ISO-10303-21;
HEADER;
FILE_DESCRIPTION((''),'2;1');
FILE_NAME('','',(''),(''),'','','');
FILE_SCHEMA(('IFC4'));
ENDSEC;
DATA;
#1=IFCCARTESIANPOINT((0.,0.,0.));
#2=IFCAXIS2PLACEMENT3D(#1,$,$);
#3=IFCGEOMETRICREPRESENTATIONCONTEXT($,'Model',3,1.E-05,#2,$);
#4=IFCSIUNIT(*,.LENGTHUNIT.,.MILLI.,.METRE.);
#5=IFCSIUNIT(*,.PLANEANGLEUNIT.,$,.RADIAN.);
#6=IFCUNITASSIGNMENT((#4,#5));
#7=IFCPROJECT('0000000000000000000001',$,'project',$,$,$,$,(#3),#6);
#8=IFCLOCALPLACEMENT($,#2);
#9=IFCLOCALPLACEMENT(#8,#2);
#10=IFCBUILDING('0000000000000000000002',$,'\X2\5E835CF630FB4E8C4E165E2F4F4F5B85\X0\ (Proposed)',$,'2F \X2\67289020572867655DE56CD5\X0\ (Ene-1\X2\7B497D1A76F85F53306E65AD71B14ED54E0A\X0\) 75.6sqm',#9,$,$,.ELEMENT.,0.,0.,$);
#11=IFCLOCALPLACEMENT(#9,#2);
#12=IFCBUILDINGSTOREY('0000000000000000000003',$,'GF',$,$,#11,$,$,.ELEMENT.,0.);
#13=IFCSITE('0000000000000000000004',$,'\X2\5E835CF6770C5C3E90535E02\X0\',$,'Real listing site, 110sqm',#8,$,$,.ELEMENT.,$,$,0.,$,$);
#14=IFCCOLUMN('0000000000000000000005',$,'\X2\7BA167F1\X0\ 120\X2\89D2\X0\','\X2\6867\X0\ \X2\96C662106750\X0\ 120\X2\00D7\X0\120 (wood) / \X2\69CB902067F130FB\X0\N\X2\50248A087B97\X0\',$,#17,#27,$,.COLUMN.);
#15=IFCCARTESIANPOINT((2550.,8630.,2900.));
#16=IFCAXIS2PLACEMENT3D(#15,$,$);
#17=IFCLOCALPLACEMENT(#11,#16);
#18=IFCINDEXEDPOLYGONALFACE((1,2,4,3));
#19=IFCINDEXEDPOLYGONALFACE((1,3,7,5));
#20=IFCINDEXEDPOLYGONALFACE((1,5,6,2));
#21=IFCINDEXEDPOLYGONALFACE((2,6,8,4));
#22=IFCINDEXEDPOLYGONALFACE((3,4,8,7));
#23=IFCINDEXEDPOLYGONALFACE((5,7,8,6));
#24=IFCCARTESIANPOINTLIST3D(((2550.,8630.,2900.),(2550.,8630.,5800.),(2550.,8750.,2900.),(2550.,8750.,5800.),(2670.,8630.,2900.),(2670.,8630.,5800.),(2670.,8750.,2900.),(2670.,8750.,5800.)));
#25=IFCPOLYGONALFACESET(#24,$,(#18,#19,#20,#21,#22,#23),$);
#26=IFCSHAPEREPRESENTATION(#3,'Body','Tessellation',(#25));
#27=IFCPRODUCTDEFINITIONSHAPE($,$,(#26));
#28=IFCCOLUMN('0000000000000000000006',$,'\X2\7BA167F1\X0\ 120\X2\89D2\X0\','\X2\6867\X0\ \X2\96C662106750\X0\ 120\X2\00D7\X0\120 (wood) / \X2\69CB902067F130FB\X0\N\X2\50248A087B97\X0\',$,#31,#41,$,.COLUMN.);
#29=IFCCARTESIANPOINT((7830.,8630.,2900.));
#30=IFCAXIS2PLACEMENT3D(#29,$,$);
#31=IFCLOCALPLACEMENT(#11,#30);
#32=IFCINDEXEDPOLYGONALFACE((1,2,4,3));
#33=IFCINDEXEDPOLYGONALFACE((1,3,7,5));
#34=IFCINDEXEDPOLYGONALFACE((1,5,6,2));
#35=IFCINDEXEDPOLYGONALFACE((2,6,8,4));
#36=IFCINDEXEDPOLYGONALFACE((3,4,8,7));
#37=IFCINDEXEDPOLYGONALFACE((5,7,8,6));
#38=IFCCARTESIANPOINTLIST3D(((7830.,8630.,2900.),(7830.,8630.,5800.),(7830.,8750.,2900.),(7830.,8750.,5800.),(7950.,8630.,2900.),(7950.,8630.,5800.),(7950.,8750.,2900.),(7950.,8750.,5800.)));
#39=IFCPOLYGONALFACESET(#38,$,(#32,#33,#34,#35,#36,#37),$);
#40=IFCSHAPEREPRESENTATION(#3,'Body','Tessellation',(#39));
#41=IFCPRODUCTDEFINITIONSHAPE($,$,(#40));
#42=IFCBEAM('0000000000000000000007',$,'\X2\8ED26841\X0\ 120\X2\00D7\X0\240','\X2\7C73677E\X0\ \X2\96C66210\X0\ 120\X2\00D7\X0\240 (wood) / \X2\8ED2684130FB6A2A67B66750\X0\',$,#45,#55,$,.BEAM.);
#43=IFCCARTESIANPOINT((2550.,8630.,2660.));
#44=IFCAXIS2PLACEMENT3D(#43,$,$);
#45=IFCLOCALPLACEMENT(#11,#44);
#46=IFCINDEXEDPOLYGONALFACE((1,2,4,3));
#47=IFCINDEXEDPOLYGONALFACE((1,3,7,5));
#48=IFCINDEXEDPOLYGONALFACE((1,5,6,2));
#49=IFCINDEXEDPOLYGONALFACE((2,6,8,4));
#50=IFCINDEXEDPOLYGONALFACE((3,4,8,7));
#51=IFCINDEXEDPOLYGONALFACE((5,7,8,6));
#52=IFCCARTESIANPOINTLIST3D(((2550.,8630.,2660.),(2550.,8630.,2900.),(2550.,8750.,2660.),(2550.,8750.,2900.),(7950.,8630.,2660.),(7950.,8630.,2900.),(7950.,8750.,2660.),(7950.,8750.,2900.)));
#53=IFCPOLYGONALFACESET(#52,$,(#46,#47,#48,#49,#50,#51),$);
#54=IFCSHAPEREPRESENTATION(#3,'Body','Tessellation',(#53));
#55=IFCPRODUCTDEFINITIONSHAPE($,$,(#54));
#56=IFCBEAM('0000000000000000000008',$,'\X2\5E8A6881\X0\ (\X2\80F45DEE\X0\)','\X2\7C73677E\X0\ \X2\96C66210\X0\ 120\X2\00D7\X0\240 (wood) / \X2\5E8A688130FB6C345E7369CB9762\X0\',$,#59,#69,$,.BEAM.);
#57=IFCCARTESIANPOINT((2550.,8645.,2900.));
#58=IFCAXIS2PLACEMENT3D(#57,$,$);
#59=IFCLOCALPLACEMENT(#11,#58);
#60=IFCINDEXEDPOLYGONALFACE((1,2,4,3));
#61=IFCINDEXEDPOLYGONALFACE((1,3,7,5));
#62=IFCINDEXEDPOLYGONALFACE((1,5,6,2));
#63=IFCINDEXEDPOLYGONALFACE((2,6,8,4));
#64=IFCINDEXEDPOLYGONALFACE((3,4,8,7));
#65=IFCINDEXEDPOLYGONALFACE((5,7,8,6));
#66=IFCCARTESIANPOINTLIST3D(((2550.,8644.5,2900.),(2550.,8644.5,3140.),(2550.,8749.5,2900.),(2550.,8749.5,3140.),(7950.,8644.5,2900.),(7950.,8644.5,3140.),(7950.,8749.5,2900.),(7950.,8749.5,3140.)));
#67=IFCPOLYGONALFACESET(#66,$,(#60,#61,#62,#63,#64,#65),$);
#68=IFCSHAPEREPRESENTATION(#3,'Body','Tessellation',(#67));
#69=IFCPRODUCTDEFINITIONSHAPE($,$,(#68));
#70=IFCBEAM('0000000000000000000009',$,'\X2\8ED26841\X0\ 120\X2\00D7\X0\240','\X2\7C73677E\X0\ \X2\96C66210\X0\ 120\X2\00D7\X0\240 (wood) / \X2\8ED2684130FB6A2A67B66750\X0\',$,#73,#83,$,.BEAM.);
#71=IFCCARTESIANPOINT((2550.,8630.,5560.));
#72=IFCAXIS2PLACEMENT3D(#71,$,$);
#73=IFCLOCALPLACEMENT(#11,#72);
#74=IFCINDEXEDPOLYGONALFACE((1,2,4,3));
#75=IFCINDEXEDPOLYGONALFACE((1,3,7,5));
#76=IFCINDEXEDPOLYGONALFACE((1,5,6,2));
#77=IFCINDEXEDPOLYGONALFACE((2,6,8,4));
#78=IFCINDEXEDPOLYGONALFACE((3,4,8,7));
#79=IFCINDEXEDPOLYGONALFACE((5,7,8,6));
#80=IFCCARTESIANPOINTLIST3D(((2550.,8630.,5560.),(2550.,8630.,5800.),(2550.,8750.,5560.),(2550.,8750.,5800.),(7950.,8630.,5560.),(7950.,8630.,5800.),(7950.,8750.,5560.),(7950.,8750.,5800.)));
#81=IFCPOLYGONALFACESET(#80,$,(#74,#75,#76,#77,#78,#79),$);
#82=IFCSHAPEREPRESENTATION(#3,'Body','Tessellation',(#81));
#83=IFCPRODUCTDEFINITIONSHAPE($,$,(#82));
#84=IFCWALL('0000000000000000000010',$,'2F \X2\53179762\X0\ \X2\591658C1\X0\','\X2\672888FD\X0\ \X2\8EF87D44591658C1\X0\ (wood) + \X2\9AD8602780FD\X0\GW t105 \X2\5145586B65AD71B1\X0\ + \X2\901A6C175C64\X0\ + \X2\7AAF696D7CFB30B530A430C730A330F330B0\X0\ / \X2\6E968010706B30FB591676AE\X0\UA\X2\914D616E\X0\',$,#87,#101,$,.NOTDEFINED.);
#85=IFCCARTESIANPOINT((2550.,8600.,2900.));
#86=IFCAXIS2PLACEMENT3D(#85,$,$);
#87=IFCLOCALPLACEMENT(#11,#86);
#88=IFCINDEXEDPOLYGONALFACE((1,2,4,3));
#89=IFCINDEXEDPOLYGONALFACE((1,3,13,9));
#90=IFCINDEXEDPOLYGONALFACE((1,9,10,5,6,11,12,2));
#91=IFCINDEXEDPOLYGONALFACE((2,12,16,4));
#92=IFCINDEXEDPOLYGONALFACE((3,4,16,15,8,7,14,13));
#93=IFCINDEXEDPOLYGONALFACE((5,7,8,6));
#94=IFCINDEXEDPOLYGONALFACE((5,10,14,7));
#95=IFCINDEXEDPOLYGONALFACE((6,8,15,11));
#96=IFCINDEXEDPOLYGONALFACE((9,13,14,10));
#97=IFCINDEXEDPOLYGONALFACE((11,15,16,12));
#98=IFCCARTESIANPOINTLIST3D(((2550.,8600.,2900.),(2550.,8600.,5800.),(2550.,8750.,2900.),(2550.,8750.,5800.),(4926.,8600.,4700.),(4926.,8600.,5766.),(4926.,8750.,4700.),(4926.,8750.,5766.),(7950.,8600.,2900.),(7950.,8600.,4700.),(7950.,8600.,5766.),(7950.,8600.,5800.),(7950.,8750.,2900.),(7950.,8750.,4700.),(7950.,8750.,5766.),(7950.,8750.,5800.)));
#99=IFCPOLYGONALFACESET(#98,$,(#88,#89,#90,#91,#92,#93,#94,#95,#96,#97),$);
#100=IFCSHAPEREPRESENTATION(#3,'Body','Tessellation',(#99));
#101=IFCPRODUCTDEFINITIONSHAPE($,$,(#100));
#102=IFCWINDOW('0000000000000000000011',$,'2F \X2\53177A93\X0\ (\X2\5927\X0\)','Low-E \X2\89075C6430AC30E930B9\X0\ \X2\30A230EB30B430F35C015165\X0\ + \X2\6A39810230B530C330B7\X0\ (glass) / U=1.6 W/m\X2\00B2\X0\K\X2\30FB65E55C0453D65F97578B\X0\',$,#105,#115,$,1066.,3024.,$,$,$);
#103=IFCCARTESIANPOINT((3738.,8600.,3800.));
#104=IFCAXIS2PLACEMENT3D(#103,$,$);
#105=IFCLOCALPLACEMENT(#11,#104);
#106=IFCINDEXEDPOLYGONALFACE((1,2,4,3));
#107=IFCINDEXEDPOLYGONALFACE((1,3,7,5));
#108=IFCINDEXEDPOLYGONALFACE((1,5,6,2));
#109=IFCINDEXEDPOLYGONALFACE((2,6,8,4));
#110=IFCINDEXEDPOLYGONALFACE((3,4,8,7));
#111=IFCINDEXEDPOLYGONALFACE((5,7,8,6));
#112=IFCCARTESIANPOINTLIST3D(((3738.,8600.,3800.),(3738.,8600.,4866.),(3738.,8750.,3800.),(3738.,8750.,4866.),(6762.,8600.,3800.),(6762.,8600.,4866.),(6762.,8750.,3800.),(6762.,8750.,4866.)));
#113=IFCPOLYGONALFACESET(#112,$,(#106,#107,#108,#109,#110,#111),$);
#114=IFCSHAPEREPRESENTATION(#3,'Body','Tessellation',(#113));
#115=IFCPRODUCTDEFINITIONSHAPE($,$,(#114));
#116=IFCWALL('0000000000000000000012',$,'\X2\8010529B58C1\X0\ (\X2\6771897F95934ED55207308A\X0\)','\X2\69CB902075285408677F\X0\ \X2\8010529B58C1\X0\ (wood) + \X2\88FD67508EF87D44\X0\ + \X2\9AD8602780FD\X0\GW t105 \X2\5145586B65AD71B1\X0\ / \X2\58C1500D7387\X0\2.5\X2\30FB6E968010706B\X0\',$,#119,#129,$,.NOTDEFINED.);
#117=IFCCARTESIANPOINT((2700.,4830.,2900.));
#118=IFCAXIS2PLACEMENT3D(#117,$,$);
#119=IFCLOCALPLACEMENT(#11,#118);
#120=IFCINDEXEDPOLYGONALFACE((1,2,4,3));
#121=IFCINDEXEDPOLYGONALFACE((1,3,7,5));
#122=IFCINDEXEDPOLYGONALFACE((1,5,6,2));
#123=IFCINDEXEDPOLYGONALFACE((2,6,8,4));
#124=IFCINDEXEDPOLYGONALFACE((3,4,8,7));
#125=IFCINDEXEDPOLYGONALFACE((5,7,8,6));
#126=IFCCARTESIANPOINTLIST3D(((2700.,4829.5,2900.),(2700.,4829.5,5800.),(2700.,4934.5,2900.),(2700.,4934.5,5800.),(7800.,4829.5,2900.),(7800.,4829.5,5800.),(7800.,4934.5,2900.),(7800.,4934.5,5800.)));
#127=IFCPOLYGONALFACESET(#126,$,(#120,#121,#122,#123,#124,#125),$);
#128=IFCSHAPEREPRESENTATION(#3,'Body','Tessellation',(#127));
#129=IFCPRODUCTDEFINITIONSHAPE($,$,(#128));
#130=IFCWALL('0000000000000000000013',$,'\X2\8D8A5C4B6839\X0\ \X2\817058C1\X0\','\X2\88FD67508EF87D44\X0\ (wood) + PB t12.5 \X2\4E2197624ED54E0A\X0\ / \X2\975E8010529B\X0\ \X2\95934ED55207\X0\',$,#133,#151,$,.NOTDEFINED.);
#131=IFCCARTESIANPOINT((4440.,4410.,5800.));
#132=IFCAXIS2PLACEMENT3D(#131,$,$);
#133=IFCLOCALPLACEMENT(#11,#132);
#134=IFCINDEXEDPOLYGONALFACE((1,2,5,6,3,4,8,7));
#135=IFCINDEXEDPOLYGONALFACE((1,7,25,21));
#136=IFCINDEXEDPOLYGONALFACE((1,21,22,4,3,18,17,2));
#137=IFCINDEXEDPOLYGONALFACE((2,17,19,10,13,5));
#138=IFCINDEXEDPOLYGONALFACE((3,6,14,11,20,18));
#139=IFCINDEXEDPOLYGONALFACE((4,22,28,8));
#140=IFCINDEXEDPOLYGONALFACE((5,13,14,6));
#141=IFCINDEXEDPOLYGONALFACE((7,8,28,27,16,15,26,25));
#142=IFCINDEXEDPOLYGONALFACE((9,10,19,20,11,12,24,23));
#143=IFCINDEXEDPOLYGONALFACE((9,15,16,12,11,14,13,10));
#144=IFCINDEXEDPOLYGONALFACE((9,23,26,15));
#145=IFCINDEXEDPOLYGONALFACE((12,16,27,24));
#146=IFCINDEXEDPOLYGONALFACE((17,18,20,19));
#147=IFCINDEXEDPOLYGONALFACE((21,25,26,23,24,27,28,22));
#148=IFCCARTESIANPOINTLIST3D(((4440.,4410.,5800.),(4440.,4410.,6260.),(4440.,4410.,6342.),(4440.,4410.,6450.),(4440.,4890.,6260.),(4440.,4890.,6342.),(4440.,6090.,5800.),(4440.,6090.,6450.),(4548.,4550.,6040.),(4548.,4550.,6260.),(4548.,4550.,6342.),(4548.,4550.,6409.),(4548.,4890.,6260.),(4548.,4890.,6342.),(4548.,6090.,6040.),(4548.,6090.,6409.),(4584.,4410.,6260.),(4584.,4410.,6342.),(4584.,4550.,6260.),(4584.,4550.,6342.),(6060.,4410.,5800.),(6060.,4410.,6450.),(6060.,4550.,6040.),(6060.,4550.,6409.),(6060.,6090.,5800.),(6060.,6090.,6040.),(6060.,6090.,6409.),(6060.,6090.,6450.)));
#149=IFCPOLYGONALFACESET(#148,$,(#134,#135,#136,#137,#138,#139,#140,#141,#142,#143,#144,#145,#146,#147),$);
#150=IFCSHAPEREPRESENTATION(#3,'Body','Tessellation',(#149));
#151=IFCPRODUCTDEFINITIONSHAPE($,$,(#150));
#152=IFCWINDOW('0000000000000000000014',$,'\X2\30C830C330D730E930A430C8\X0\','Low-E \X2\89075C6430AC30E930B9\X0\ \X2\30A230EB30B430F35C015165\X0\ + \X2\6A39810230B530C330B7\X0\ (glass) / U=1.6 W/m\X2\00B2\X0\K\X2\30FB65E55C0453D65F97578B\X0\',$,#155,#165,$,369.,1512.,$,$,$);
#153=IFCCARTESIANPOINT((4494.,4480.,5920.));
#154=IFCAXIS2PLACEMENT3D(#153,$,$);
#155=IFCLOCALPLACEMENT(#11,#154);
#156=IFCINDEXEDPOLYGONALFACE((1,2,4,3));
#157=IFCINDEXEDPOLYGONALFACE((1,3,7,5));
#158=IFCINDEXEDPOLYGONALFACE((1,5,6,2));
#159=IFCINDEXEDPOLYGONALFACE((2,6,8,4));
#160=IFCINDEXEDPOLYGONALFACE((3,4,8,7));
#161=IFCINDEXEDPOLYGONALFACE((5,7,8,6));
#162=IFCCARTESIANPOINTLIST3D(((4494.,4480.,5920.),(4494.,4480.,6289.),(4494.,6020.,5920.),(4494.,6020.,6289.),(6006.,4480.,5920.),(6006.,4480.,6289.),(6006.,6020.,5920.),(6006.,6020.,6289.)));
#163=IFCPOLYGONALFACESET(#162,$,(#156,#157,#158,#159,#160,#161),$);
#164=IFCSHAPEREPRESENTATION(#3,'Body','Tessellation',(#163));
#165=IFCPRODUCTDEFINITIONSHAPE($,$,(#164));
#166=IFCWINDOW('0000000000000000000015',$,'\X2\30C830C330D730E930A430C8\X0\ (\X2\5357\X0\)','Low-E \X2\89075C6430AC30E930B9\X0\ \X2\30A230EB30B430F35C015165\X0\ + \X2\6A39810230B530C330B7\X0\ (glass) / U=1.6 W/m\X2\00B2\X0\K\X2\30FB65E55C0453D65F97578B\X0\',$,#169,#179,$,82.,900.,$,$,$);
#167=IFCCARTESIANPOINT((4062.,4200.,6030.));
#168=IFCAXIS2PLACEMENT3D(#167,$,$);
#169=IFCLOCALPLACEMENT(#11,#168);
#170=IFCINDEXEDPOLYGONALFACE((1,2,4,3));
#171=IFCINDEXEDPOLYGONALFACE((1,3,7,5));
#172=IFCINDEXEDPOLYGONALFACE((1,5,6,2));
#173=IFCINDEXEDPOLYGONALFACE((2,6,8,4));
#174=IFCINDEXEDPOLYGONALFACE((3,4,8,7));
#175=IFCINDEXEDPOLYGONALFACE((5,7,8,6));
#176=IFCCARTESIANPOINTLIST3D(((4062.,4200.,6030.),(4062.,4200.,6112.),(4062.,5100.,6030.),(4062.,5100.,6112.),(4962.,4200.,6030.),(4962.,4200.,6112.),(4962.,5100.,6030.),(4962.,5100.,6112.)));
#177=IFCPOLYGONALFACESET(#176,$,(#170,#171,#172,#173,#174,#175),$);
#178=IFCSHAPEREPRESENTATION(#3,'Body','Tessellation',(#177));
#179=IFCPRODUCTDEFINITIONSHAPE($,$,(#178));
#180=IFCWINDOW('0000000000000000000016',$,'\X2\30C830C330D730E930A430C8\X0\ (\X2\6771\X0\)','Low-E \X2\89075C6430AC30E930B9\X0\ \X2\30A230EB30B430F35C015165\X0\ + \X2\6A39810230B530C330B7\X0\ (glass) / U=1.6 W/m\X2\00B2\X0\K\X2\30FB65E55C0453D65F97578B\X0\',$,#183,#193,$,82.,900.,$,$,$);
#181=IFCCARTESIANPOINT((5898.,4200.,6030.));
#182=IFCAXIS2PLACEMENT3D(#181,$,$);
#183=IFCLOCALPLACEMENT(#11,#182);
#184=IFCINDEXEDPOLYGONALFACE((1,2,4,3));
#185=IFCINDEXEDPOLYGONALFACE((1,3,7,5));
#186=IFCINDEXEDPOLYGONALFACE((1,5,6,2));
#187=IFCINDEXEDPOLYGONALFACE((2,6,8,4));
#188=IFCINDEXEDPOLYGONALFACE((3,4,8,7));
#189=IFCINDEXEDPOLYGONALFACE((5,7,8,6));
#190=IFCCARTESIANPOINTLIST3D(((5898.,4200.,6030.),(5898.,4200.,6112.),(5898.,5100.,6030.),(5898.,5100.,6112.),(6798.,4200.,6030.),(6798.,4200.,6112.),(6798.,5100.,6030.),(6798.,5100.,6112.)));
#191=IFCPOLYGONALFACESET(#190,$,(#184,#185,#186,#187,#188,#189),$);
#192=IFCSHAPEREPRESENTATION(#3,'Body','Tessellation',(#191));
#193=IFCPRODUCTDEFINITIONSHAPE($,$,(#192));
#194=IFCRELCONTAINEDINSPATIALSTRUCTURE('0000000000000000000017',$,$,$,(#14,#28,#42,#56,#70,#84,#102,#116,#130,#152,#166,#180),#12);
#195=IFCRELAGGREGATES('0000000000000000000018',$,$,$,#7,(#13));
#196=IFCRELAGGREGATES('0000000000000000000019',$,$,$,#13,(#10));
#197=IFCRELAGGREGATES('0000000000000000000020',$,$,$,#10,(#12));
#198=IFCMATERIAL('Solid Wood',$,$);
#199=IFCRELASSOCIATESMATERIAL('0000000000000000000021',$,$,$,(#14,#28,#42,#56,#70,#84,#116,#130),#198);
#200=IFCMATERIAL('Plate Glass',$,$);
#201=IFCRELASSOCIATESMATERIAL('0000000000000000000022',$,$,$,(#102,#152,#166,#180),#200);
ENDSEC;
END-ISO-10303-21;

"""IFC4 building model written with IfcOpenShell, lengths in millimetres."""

from ifc_helpers import new_model, si_unit, frame, frame_2d, origin, place, context, project, spatial, rectangle, extrude, material, element, fill, save


model = new_model("IFC4")

# Units and contexts
model_context = context("Model", 3, precision=1e-05, world=origin())
ifc_project = project(units=[si_unit("LENGTHUNIT", "METRE", prefix="MILLI"), si_unit("PLANEANGLEUNIT", "RADIAN")], contexts=[model_context])

# Site, building, storey
site_placement = place(None, origin())
site = spatial("IfcSite", under=ifc_project, at=site_placement, Name="広島県尾道市", ObjectType="Real listing site, 110sqm", CompositionType="ELEMENT", RefElevation=0.0)
building_placement = place(site_placement, origin())
building = spatial("IfcBuilding", under=site, at=building_placement, Name="広島・二世帯住宅 (Proposed)", ObjectType="2F 木造在来工法 (Ene-1等級相当の断熱仕上) 75.6sqm", CompositionType="ELEMENT", ElevationOfRefHeight=0.0, ElevationOfTerrain=0.0)
storey_placement = place(building_placement, origin())
storey = spatial("IfcBuildingStorey", under=building, at=storey_placement, Name="GF", CompositionType="ELEMENT", Elevation=0.0)

# Columns
ifc_material_1 = material(Name="Solid Wood")
column_1_placement = place(storey_placement, frame((2550.0, 8630.0, 2900.0)))
element("IfcColumn", 1, at=column_1_placement, inside=storey, material=ifc_material_1, Name="管柱 120角", Description="桧 集成材 120×120 (wood) / 構造柱・N値計算", PredefinedType="COLUMN", context=model_context, shape_type="SweptSolid", body=[
    extrude(rectangle(XDim=120.0, YDim=120.0, at=frame_2d((60.0, 60.0))), frame((2550.0, 8630.0, 2900.0)), (0.0, 0.0, 1.0), 2900.0),
])
column_2_placement = place(storey_placement, frame((7830.0, 8630.0, 2900.0)))
element("IfcColumn", 2, at=column_2_placement, inside=storey, material=ifc_material_1, Name="管柱 120角", Description="桧 集成材 120×120 (wood) / 構造柱・N値計算", PredefinedType="COLUMN", context=model_context, shape_type="SweptSolid", body=[
    extrude(rectangle(XDim=120.0, YDim=120.0, at=frame_2d((60.0, 60.0))), frame((7830.0, 8630.0, 2900.0)), (0.0, 0.0, 1.0), 2900.0),
])

# Beams
beam_1_placement = place(storey_placement, frame((2550.0, 8630.0, 2660.0)))
element("IfcBeam", 3, at=beam_1_placement, inside=storey, material=ifc_material_1, Name="軒桁 120×240", Description="米松 集成 120×240 (wood) / 軒桁・横架材", PredefinedType="BEAM", context=model_context, shape_type="SweptSolid", body=[
    extrude(rectangle(XDim=5400.0, YDim=120.0, at=frame_2d((2700.0, 60.0))), frame((2550.0, 8630.0, 2660.0)), (0.0, 0.0, 1.0), 240.0),
])
beam_2_placement = place(storey_placement, frame((2550.0, 8645.0, 2900.0)))
element("IfcBeam", 4, at=beam_2_placement, inside=storey, material=ifc_material_1, Name="床梁 (胴差)", Description="米松 集成 120×240 (wood) / 床梁・水平構面", PredefinedType="BEAM", context=model_context, shape_type="SweptSolid", body=[
    extrude(rectangle(XDim=5400.0, YDim=105.0, at=frame_2d((2700.0, 52.0))), frame((2550.0, 8645.0, 2900.0)), (0.0, 0.0, 1.0), 240.0),
])
beam_3_placement = place(storey_placement, frame((2550.0, 8630.0, 5560.0)))
element("IfcBeam", 5, at=beam_3_placement, inside=storey, material=ifc_material_1, Name="軒桁 120×240", Description="米松 集成 120×240 (wood) / 軒桁・横架材", PredefinedType="BEAM", context=model_context, shape_type="SweptSolid", body=[
    extrude(rectangle(XDim=5400.0, YDim=120.0, at=frame_2d((2700.0, 60.0))), frame((2550.0, 8630.0, 5560.0)), (0.0, 0.0, 1.0), 240.0),
])

# Wall, opening, window
wall_1_placement = place(storey_placement, frame((2550.0, 8600.0, 2900.0)))
wall_1 = element("IfcWall", 6, at=wall_1_placement, inside=storey, material=ifc_material_1, Name="2F 北面 外壁", Description="木製 軸組外壁 (wood) + 高性能GW t105 充填断熱 + 通気層 + 窯業系サイディング / 準耐火・外皮UA配慮", PredefinedType="NOTDEFINED", context=model_context, shape_type="SweptSolid", body=[
    extrude(rectangle(XDim=5400.0, YDim=150.0, at=frame_2d((2700.0, 75.0))), frame((2550.0, 8600.0, 2900.0)), (0.0, 0.0, 1.0), 2900.0),
])
opening_1_placement = place(storey_placement, frame((3738.0, 8600.0, 3800.0)))
opening_1 = element("IfcOpeningElement", 7, at=opening_1_placement, cuts=wall_1, PredefinedType="NOTDEFINED", context=model_context, shape_type="SweptSolid", body=[
    extrude(rectangle(XDim=3024.0, YDim=150.0, at=frame_2d((1512.0, 75.0))), frame((3738.0, 8600.0, 3800.0)), (0.0, 0.0, 1.0), 1066.0),
])
ifc_material_2 = material(Name="Plate Glass")
window_1_placement = place(storey_placement, frame((3738.0, 8600.0, 3800.0)))
window_1 = element("IfcWindow", 8, at=window_1_placement, inside=storey, material=ifc_material_2, Name="2F 北窓 (大)", Description="Low-E 複層ガラス アルゴン封入 + 樹脂サッシ (glass) / U=1.6 W/m²K・日射取得型", OverallHeight=1066.0, OverallWidth=3024.0, context=model_context, shape_type="SweptSolid", body=[
    extrude(rectangle(XDim=3024.0, YDim=150.0, at=frame_2d((1512.0, 75.0))), frame((3738.0, 8600.0, 3800.0)), (0.0, 0.0, 1.0), 1066.0),
])
fill(opening_1, window_1)

# Wall
wall_2_placement = place(storey_placement, frame((2700.0, 4830.0, 2900.0)))
element("IfcWall", 9, at=wall_2_placement, inside=storey, material=ifc_material_1, Name="耐力壁 (東西間仕切り)", Description="構造用合板 耐力壁 (wood) + 製材軸組 + 高性能GW t105 充填断熱 / 壁倍率2.5・準耐火", PredefinedType="NOTDEFINED", context=model_context, shape_type="SweptSolid", body=[
    extrude(rectangle(XDim=5100.0, YDim=105.0, at=frame_2d((2550.0, 52.0))), frame((2700.0, 4830.0, 2900.0)), (0.0, 0.0, 1.0), 2900.0),
])

# Wall, openings, windows
wall_3_placement = place(storey_placement, frame((4440.0, 4410.0, 5800.0)))
wall_3 = element("IfcWall", 10, at=wall_3_placement, inside=storey, material=ifc_material_1, Name="越屋根 腰壁", Description="製材軸組 (wood) + PB t12.5 両面仕上 / 非耐力 間仕切", PredefinedType="NOTDEFINED", context=model_context, shape_type="SweptSolid", body=[
    extrude(rectangle(XDim=1620.0, YDim=1680.0, at=frame_2d((810.0, 840.0))), frame((4440.0, 4410.0, 5800.0)), (0.0, 0.0, 1.0), 650.0),
])
opening_2_placement = place(storey_placement, frame((4494.0, 4480.0, 5920.0)))
opening_2 = element("IfcOpeningElement", 11, at=opening_2_placement, cuts=wall_3, PredefinedType="NOTDEFINED", context=model_context, shape_type="SweptSolid", body=[
    extrude(rectangle(XDim=1512.0, YDim=1540.0, at=frame_2d((756.0, 770.0))), frame((4494.0, 4480.0, 5920.0)), (0.0, 0.0, 1.0), 369.0),
])
opening_3_placement = place(storey_placement, frame((4062.0, 4200.0, 6030.0)))
opening_3 = element("IfcOpeningElement", 12, at=opening_3_placement, cuts=wall_3, PredefinedType="NOTDEFINED", context=model_context, shape_type="SweptSolid", body=[
    extrude(rectangle(XDim=900.0, YDim=900.0, at=frame_2d((450.0, 450.0))), frame((4062.0, 4200.0, 6030.0)), (0.0, 0.0, 1.0), 82.0),
])
opening_4_placement = place(storey_placement, frame((5898.0, 4200.0, 6030.0)))
opening_4 = element("IfcOpeningElement", 13, at=opening_4_placement, cuts=wall_3, PredefinedType="NOTDEFINED", context=model_context, shape_type="SweptSolid", body=[
    extrude(rectangle(XDim=900.0, YDim=900.0, at=frame_2d((450.0, 450.0))), frame((5898.0, 4200.0, 6030.0)), (0.0, 0.0, 1.0), 82.0),
])
window_2_placement = place(storey_placement, frame((4494.0, 4480.0, 5920.0)))
window_2 = element("IfcWindow", 14, at=window_2_placement, inside=storey, material=ifc_material_2, Name="トップライト", Description="Low-E 複層ガラス アルゴン封入 + 樹脂サッシ (glass) / U=1.6 W/m²K・日射取得型", OverallHeight=369.0, OverallWidth=1512.0, context=model_context, shape_type="SweptSolid", body=[
    extrude(rectangle(XDim=1512.0, YDim=1540.0, at=frame_2d((756.0, 770.0))), frame((4494.0, 4480.0, 5920.0)), (0.0, 0.0, 1.0), 369.0),
])
fill(opening_2, window_2)
window_3_placement = place(storey_placement, frame((4062.0, 4200.0, 6030.0)))
window_3 = element("IfcWindow", 15, at=window_3_placement, inside=storey, material=ifc_material_2, Name="トップライト (南)", Description="Low-E 複層ガラス アルゴン封入 + 樹脂サッシ (glass) / U=1.6 W/m²K・日射取得型", OverallHeight=82.0, OverallWidth=900.0, context=model_context, shape_type="SweptSolid", body=[
    extrude(rectangle(XDim=900.0, YDim=900.0, at=frame_2d((450.0, 450.0))), frame((4062.0, 4200.0, 6030.0)), (0.0, 0.0, 1.0), 82.0),
])
fill(opening_3, window_3)
window_4_placement = place(storey_placement, frame((5898.0, 4200.0, 6030.0)))
window_4 = element("IfcWindow", 16, at=window_4_placement, inside=storey, material=ifc_material_2, Name="トップライト (東)", Description="Low-E 複層ガラス アルゴン封入 + 樹脂サッシ (glass) / U=1.6 W/m²K・日射取得型", OverallHeight=82.0, OverallWidth=900.0, context=model_context, shape_type="SweptSolid", body=[
    extrude(rectangle(XDim=900.0, YDim=900.0, at=frame_2d((450.0, 450.0))), frame((5898.0, 4200.0, 6030.0)), (0.0, 0.0, 1.0), 82.0),
])
fill(opening_4, window_4)

save(model, "model.ifc")
